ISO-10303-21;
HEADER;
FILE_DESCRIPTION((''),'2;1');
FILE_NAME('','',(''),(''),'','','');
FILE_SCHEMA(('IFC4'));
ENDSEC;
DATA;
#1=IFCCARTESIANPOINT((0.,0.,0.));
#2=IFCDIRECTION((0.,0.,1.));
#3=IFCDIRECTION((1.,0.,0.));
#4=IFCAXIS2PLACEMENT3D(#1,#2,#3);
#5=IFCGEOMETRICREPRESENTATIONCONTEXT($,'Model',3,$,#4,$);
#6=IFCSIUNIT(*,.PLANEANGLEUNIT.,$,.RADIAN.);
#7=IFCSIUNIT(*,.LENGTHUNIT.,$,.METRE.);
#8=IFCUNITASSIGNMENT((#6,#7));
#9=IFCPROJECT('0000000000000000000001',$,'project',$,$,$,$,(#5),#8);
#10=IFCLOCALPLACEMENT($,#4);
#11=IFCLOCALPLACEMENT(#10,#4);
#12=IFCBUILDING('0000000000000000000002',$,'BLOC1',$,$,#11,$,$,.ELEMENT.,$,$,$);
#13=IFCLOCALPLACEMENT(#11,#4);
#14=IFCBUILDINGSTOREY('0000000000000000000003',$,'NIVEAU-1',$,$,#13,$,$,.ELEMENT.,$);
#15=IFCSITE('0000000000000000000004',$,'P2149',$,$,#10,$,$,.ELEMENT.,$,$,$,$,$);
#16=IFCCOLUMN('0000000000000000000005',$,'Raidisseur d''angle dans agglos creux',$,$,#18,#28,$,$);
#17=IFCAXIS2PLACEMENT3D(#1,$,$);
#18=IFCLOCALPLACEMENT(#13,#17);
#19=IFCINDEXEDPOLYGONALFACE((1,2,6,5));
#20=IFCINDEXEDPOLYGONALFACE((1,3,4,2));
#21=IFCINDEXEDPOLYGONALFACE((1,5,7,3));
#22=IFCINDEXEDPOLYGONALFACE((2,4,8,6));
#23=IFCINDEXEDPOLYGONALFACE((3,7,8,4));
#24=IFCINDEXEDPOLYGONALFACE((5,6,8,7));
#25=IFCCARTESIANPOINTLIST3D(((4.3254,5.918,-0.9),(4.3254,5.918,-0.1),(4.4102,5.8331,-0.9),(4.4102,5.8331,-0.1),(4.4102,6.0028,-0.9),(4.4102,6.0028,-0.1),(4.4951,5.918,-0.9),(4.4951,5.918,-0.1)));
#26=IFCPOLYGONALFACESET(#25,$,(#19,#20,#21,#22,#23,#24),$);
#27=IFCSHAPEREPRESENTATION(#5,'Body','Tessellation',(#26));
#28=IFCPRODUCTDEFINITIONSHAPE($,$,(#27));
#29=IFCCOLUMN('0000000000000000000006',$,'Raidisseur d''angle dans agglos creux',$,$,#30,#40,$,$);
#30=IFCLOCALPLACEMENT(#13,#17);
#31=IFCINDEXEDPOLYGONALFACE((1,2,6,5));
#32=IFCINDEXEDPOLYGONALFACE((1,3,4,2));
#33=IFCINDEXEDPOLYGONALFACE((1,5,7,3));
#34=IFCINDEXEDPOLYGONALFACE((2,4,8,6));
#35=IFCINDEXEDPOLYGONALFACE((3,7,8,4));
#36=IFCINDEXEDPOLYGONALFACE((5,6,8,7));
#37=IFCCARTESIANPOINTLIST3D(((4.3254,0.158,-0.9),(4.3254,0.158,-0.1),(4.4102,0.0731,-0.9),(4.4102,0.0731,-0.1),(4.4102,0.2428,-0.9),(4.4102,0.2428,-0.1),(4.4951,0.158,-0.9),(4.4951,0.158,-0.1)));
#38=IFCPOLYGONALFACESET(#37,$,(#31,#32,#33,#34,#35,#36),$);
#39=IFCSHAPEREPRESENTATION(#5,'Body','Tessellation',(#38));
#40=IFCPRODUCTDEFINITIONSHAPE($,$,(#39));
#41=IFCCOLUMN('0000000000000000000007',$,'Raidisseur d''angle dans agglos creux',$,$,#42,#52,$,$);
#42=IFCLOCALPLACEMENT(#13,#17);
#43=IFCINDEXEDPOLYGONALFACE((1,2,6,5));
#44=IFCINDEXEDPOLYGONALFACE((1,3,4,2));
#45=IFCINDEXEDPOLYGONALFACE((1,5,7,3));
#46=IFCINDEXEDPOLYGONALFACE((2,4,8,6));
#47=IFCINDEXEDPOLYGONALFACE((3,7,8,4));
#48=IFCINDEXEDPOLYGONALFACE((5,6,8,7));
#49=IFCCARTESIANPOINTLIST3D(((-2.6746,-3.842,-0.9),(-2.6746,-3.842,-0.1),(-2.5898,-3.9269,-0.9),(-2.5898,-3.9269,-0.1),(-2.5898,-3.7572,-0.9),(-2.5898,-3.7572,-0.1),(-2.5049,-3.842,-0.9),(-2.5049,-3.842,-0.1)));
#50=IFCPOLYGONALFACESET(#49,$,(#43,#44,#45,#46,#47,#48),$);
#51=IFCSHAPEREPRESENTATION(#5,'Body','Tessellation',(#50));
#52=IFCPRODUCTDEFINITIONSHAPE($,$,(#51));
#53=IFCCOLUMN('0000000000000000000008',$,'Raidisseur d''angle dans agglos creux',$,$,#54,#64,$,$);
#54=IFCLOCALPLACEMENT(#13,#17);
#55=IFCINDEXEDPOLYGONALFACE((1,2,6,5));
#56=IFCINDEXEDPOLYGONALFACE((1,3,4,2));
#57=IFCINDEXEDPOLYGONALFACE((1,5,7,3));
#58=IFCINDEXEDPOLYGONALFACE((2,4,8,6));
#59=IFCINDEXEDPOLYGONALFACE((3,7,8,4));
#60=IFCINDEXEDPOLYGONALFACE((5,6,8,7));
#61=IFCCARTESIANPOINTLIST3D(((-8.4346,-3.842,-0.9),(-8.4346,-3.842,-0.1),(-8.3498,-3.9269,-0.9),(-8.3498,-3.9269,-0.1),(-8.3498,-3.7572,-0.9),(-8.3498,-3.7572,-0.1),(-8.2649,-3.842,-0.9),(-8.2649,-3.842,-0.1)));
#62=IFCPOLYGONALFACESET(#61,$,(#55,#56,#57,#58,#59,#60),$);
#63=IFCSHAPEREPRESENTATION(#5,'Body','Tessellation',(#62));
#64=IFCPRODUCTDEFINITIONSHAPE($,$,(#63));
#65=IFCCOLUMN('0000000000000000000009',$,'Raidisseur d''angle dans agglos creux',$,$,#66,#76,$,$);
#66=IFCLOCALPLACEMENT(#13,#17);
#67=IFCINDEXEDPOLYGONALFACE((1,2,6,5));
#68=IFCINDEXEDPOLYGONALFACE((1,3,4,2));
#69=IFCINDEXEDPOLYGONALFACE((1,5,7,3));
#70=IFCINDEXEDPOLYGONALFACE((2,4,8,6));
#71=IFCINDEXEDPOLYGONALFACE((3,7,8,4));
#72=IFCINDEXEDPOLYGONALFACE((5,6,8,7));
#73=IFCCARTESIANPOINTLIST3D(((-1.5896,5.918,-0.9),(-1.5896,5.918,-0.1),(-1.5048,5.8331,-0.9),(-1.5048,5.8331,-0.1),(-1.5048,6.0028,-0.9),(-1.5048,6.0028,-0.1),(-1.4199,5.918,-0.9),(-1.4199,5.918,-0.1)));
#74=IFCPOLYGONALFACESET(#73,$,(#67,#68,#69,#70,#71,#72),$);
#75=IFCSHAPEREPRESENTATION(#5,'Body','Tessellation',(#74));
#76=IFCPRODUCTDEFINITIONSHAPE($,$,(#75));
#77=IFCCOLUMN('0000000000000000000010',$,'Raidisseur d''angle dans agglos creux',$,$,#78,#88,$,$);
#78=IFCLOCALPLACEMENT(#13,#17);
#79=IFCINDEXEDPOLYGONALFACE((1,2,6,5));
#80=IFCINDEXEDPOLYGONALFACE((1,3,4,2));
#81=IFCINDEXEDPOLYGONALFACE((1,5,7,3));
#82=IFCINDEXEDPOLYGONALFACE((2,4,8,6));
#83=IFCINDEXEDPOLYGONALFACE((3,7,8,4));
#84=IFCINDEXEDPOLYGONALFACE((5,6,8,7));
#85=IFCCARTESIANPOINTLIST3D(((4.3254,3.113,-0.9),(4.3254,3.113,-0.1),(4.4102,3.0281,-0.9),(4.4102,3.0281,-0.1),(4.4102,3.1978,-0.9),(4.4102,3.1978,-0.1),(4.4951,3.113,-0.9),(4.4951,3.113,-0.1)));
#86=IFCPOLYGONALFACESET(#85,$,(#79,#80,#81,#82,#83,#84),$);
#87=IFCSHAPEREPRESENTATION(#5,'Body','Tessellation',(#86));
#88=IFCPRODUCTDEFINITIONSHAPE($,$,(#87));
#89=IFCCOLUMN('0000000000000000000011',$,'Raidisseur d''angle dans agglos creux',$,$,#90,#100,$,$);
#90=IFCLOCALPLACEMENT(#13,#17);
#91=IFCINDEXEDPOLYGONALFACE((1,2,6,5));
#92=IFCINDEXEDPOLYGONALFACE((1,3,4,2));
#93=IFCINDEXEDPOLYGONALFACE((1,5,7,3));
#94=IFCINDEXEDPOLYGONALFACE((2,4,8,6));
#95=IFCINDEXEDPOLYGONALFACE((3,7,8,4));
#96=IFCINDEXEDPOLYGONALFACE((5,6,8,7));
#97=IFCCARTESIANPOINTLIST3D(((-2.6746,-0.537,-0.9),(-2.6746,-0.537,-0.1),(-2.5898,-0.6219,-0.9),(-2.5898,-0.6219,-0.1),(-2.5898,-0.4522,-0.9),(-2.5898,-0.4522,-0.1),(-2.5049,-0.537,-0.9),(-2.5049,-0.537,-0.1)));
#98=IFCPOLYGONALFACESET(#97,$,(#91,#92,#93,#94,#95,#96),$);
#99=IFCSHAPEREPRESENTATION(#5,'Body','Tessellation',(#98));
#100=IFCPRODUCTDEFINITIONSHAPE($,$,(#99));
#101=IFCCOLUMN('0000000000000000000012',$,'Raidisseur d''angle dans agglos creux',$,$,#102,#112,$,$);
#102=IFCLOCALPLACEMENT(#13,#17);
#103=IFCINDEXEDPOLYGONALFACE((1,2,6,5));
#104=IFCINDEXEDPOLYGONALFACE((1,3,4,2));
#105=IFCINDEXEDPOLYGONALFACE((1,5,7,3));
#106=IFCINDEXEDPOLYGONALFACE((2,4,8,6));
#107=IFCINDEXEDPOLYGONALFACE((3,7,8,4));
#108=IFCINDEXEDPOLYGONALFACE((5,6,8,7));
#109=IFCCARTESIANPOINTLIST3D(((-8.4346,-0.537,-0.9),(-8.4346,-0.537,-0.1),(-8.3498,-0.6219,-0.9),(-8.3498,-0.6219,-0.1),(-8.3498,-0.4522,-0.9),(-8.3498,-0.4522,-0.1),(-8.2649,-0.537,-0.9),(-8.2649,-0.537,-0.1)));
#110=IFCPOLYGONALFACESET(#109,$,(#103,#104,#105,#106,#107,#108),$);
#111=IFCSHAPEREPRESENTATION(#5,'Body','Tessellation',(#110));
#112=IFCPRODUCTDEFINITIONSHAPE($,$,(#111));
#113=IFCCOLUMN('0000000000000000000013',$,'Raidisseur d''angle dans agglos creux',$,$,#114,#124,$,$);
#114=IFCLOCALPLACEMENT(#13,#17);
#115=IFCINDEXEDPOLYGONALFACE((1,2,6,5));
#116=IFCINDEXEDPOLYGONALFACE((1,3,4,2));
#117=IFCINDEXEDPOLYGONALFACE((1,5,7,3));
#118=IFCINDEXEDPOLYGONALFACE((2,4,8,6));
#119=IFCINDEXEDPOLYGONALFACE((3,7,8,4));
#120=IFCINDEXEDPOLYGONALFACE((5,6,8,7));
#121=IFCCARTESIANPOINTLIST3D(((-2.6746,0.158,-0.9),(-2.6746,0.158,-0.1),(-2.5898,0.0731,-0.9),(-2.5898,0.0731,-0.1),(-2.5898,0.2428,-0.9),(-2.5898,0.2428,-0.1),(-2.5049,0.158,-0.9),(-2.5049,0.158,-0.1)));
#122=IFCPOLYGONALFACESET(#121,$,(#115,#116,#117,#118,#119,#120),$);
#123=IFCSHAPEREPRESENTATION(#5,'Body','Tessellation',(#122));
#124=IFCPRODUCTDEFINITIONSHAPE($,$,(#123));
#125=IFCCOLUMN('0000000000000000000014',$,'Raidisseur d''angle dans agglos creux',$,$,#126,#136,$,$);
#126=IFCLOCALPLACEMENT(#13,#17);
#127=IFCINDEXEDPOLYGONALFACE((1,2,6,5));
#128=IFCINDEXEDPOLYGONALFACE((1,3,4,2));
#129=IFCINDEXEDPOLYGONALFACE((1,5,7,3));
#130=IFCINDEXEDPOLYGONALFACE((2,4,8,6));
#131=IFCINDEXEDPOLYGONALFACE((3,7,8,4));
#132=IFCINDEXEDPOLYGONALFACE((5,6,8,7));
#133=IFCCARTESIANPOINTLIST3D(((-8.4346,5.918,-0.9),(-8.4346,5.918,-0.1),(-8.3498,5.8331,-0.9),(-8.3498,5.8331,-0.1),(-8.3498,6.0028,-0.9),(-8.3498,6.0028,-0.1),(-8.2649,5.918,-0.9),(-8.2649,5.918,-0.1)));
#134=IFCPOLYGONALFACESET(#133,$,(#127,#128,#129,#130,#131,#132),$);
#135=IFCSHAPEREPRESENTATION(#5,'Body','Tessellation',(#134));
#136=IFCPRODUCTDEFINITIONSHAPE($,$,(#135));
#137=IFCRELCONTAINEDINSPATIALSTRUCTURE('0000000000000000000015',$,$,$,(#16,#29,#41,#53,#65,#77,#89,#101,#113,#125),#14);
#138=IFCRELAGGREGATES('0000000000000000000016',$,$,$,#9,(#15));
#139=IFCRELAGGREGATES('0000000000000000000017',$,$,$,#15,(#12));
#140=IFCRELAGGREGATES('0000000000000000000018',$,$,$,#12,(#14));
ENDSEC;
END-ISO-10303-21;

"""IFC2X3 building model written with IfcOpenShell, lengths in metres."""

from ifc_helpers import new_model, si_unit, point, frame, origin_with_axes, place, context, project, spatial, line_curve, trimmed, segment, composite_curve, outline, extrude, element, save


model = new_model("IFC2X3")

# Units and contexts
model_context = context("Model", 3, world=origin_with_axes())
ifc_project = project(units=[si_unit("PLANEANGLEUNIT", "RADIAN"), si_unit("LENGTHUNIT", "METRE")], contexts=[model_context])

# Site, building, storey
site_placement = place(None, origin_with_axes())
site = spatial("IfcSite", under=ifc_project, at=site_placement, Name="P2149", CompositionType="ELEMENT")
building_placement = place(site_placement, origin_with_axes())
building = spatial("IfcBuilding", under=site, at=building_placement, Name="BLOC1", CompositionType="ELEMENT")
storey_placement = place(building_placement, origin_with_axes())
storey = spatial("IfcBuildingStorey", under=building, at=storey_placement, Name="NIVEAU-1", CompositionType="ELEMENT")

# Columns
column_1_placement = place(storey_placement, origin_with_axes())
element("IfcColumn", 1, at=column_1_placement, inside=storey, Name="Raidisseur d'angle dans agglos creux", context=model_context, shape_type="SweptSolid", body=[
    extrude(outline(composite_curve([segment(trimmed(line_curve((0.0, 0.0), (1.0, 0.0), 0.12), [point((0.0, 0.0))], [point((0.12, 0.0))], True, "CARTESIAN"), True, "CONTINUOUS"), segment(trimmed(line_curve((0.12, 0.0), (0.0, 1.0), 0.12), [point((0.12, 0.0))], [point((0.12, 0.12))], True, "CARTESIAN"), True, "CONTINUOUS"), segment(trimmed(line_curve((0.12, 0.12), (-1.0, 0.0), 0.12), [point((0.12, 0.12))], [point((0.0, 0.12))], True, "CARTESIAN"), True, "CONTINUOUS"), segment(trimmed(line_curve((0.0, 0.12), (0.0, -1.0), 0.12), [point((0.0, 0.12))], [point((0.0, 0.0))], True, "CARTESIAN"), True, "CONTINUOUS")], self_intersect=False)), frame((4.3254, 5.918, -0.9), z_axis=(0.0, 0.0, -1.0), x_axis=(0.707107, 0.707107, 0.0)), (0.0, 0.0, -1.0), 0.8),
])
column_2_placement = place(storey_placement, origin_with_axes())
element("IfcColumn", 2, at=column_2_placement, inside=storey, Name="Raidisseur d'angle dans agglos creux", context=model_context, shape_type="SweptSolid", body=[
    extrude(outline(composite_curve([segment(trimmed(line_curve((0.0, 0.0), (1.0, 0.0), 0.12), [point((0.0, 0.0))], [point((0.12, 0.0))], True, "CARTESIAN"), True, "CONTINUOUS"), segment(trimmed(line_curve((0.12, 0.0), (0.0, 1.0), 0.12), [point((0.12, 0.0))], [point((0.12, 0.12))], True, "CARTESIAN"), True, "CONTINUOUS"), segment(trimmed(line_curve((0.12, 0.12), (-1.0, 0.0), 0.12), [point((0.12, 0.12))], [point((0.0, 0.12))], True, "CARTESIAN"), True, "CONTINUOUS"), segment(trimmed(line_curve((0.0, 0.12), (0.0, -1.0), 0.12), [point((0.0, 0.12))], [point((0.0, 0.0))], True, "CARTESIAN"), True, "CONTINUOUS")], self_intersect=False)), frame((4.4102, 0.2428, -0.9), z_axis=(0.0, 0.0, -1.0), x_axis=(0.707107, -0.707107, 0.0)), (0.0, 0.0, -1.0), 0.8),
])
column_3_placement = place(storey_placement, origin_with_axes())
element("IfcColumn", 3, at=column_3_placement, inside=storey, Name="Raidisseur d'angle dans agglos creux", context=model_context, shape_type="SweptSolid", body=[
    extrude(outline(composite_curve([segment(trimmed(line_curve((0.0, 0.0), (1.0, 0.0), 0.12), [point((0.0, 0.0))], [point((0.12, 0.0))], True, "CARTESIAN"), True, "CONTINUOUS"), segment(trimmed(line_curve((0.12, 0.0), (0.0, 1.0), 0.12), [point((0.12, 0.0))], [point((0.12, 0.12))], True, "CARTESIAN"), True, "CONTINUOUS"), segment(trimmed(line_curve((0.12, 0.12), (-1.0, 0.0), 0.12), [point((0.12, 0.12))], [point((0.0, 0.12))], True, "CARTESIAN"), True, "CONTINUOUS"), segment(trimmed(line_curve((0.0, 0.12), (0.0, -1.0), 0.12), [point((0.0, 0.12))], [point((0.0, 0.0))], True, "CARTESIAN"), True, "CONTINUOUS")], self_intersect=False)), frame((-2.5049, -3.842, -0.9), z_axis=(0.0, 0.0, -1.0), x_axis=(-0.707107, -0.707107, 0.0)), (0.0, 0.0, -1.0), 0.8),
])
column_4_placement = place(storey_placement, origin_with_axes())
element("IfcColumn", 4, at=column_4_placement, inside=storey, Name="Raidisseur d'angle dans agglos creux", context=model_context, shape_type="SweptSolid", body=[
    extrude(outline(composite_curve([segment(trimmed(line_curve((0.0, 0.0), (1.0, 0.0), 0.12), [point((0.0, 0.0))], [point((0.12, 0.0))], True, "CARTESIAN"), True, "CONTINUOUS"), segment(trimmed(line_curve((0.12, 0.0), (0.0, 1.0), 0.12), [point((0.12, 0.0))], [point((0.12, 0.12))], True, "CARTESIAN"), True, "CONTINUOUS"), segment(trimmed(line_curve((0.12, 0.12), (-1.0, 0.0), 0.12), [point((0.12, 0.12))], [point((0.0, 0.12))], True, "CARTESIAN"), True, "CONTINUOUS"), segment(trimmed(line_curve((0.0, 0.12), (0.0, -1.0), 0.12), [point((0.0, 0.12))], [point((0.0, 0.0))], True, "CARTESIAN"), True, "CONTINUOUS")], self_intersect=False)), frame((-8.2649, -3.842, -0.9), z_axis=(0.0, 0.0, -1.0), x_axis=(-0.707107, -0.707107, 0.0)), (0.0, 0.0, -1.0), 0.8),
])
column_5_placement = place(storey_placement, origin_with_axes())
element("IfcColumn", 5, at=column_5_placement, inside=storey, Name="Raidisseur d'angle dans agglos creux", context=model_context, shape_type="SweptSolid", body=[
    extrude(outline(composite_curve([segment(trimmed(line_curve((0.0, 0.0), (1.0, 0.0), 0.12), [point((0.0, 0.0))], [point((0.12, 0.0))], True, "CARTESIAN"), True, "CONTINUOUS"), segment(trimmed(line_curve((0.12, 0.0), (0.0, 1.0), 0.12), [point((0.12, 0.0))], [point((0.12, 0.12))], True, "CARTESIAN"), True, "CONTINUOUS"), segment(trimmed(line_curve((0.12, 0.12), (-1.0, 0.0), 0.12), [point((0.12, 0.12))], [point((0.0, 0.12))], True, "CARTESIAN"), True, "CONTINUOUS"), segment(trimmed(line_curve((0.0, 0.12), (0.0, -1.0), 0.12), [point((0.0, 0.12))], [point((0.0, 0.0))], True, "CARTESIAN"), True, "CONTINUOUS")], self_intersect=False)), frame((-1.5896, 5.918, -0.9), z_axis=(0.0, 0.0, -1.0), x_axis=(0.707107, 0.707107, 0.0)), (0.0, 0.0, -1.0), 0.8),
])
column_6_placement = place(storey_placement, origin_with_axes())
element("IfcColumn", 6, at=column_6_placement, inside=storey, Name="Raidisseur d'angle dans agglos creux", context=model_context, shape_type="SweptSolid", body=[
    extrude(outline(composite_curve([segment(trimmed(line_curve((0.0, 0.0), (1.0, 0.0), 0.12), [point((0.0, 0.0))], [point((0.12, 0.0))], True, "CARTESIAN"), True, "CONTINUOUS"), segment(trimmed(line_curve((0.12, 0.0), (0.0, 1.0), 0.12), [point((0.12, 0.0))], [point((0.12, 0.12))], True, "CARTESIAN"), True, "CONTINUOUS"), segment(trimmed(line_curve((0.12, 0.12), (-1.0, 0.0), 0.12), [point((0.12, 0.12))], [point((0.0, 0.12))], True, "CARTESIAN"), True, "CONTINUOUS"), segment(trimmed(line_curve((0.0, 0.12), (0.0, -1.0), 0.12), [point((0.0, 0.12))], [point((0.0, 0.0))], True, "CARTESIAN"), True, "CONTINUOUS")], self_intersect=False)), frame((4.4102, 3.1978, -0.9), z_axis=(0.0, 0.0, -1.0), x_axis=(0.707107, -0.707107, 0.0)), (0.0, 0.0, -1.0), 0.8),
])
column_7_placement = place(storey_placement, origin_with_axes())
element("IfcColumn", 7, at=column_7_placement, inside=storey, Name="Raidisseur d'angle dans agglos creux", context=model_context, shape_type="SweptSolid", body=[
    extrude(outline(composite_curve([segment(trimmed(line_curve((0.0, 0.0), (1.0, 0.0), 0.12), [point((0.0, 0.0))], [point((0.12, 0.0))], True, "CARTESIAN"), True, "CONTINUOUS"), segment(trimmed(line_curve((0.12, 0.0), (0.0, 1.0), 0.12), [point((0.12, 0.0))], [point((0.12, 0.12))], True, "CARTESIAN"), True, "CONTINUOUS"), segment(trimmed(line_curve((0.12, 0.12), (-1.0, 0.0), 0.12), [point((0.12, 0.12))], [point((0.0, 0.12))], True, "CARTESIAN"), True, "CONTINUOUS"), segment(trimmed(line_curve((0.0, 0.12), (0.0, -1.0), 0.12), [point((0.0, 0.12))], [point((0.0, 0.0))], True, "CARTESIAN"), True, "CONTINUOUS")], self_intersect=False)), frame((-2.5898, -0.4522, -0.9), z_axis=(0.0, 0.0, -1.0), x_axis=(0.707107, -0.707107, 0.0)), (0.0, 0.0, -1.0), 0.8),
])
column_8_placement = place(storey_placement, origin_with_axes())
element("IfcColumn", 8, at=column_8_placement, inside=storey, Name="Raidisseur d'angle dans agglos creux", context=model_context, shape_type="SweptSolid", body=[
    extrude(outline(composite_curve([segment(trimmed(line_curve((0.0, 0.0), (1.0, 0.0), 0.12), [point((0.0, 0.0))], [point((0.12, 0.0))], True, "CARTESIAN"), True, "CONTINUOUS"), segment(trimmed(line_curve((0.12, 0.0), (0.0, 1.0), 0.12), [point((0.12, 0.0))], [point((0.12, 0.12))], True, "CARTESIAN"), True, "CONTINUOUS"), segment(trimmed(line_curve((0.12, 0.12), (-1.0, 0.0), 0.12), [point((0.12, 0.12))], [point((0.0, 0.12))], True, "CARTESIAN"), True, "CONTINUOUS"), segment(trimmed(line_curve((0.0, 0.12), (0.0, -1.0), 0.12), [point((0.0, 0.12))], [point((0.0, 0.0))], True, "CARTESIAN"), True, "CONTINUOUS")], self_intersect=False)), frame((-8.3498, -0.6219, -0.9), z_axis=(0.0, 0.0, -1.0), x_axis=(-0.707107, 0.707107, 0.0)), (0.0, 0.0, -1.0), 0.8),
])
column_9_placement = place(storey_placement, origin_with_axes())
element("IfcColumn", 9, at=column_9_placement, inside=storey, Name="Raidisseur d'angle dans agglos creux", context=model_context, shape_type="SweptSolid", body=[
    extrude(outline(composite_curve([segment(trimmed(line_curve((0.0, 0.0), (1.0, 0.0), 0.12), [point((0.0, 0.0))], [point((0.12, 0.0))], True, "CARTESIAN"), True, "CONTINUOUS"), segment(trimmed(line_curve((0.12, 0.0), (0.0, 1.0), 0.12), [point((0.12, 0.0))], [point((0.12, 0.12))], True, "CARTESIAN"), True, "CONTINUOUS"), segment(trimmed(line_curve((0.12, 0.12), (-1.0, 0.0), 0.12), [point((0.12, 0.12))], [point((0.0, 0.12))], True, "CARTESIAN"), True, "CONTINUOUS"), segment(trimmed(line_curve((0.0, 0.12), (0.0, -1.0), 0.12), [point((0.0, 0.12))], [point((0.0, 0.0))], True, "CARTESIAN"), True, "CONTINUOUS")], self_intersect=False)), frame((-2.5049, 0.158, -0.9), z_axis=(0.0, 0.0, -1.0), x_axis=(-0.707107, -0.707107, 0.0)), (0.0, 0.0, -1.0), 0.8),
])
column_10_placement = place(storey_placement, origin_with_axes())
element("IfcColumn", 10, at=column_10_placement, inside=storey, Name="Raidisseur d'angle dans agglos creux", context=model_context, shape_type="SweptSolid", body=[
    extrude(outline(composite_curve([segment(trimmed(line_curve((0.0, 0.0), (1.0, 0.0), 0.12), [point((0.0, 0.0))], [point((0.12, 0.0))], True, "CARTESIAN"), True, "CONTINUOUS"), segment(trimmed(line_curve((0.12, 0.0), (0.0, 1.0), 0.12), [point((0.12, 0.0))], [point((0.12, 0.12))], True, "CARTESIAN"), True, "CONTINUOUS"), segment(trimmed(line_curve((0.12, 0.12), (-1.0, 0.0), 0.12), [point((0.12, 0.12))], [point((0.0, 0.12))], True, "CARTESIAN"), True, "CONTINUOUS"), segment(trimmed(line_curve((0.0, 0.12), (0.0, -1.0), 0.12), [point((0.0, 0.12))], [point((0.0, 0.0))], True, "CARTESIAN"), True, "CONTINUOUS")], self_intersect=False)), frame((-8.4346, 5.918, -0.9), z_axis=(0.0, 0.0, -1.0), x_axis=(0.707107, 0.707107, 0.0)), (0.0, 0.0, -1.0), 0.8),
])

save(model, "model.ifc")
